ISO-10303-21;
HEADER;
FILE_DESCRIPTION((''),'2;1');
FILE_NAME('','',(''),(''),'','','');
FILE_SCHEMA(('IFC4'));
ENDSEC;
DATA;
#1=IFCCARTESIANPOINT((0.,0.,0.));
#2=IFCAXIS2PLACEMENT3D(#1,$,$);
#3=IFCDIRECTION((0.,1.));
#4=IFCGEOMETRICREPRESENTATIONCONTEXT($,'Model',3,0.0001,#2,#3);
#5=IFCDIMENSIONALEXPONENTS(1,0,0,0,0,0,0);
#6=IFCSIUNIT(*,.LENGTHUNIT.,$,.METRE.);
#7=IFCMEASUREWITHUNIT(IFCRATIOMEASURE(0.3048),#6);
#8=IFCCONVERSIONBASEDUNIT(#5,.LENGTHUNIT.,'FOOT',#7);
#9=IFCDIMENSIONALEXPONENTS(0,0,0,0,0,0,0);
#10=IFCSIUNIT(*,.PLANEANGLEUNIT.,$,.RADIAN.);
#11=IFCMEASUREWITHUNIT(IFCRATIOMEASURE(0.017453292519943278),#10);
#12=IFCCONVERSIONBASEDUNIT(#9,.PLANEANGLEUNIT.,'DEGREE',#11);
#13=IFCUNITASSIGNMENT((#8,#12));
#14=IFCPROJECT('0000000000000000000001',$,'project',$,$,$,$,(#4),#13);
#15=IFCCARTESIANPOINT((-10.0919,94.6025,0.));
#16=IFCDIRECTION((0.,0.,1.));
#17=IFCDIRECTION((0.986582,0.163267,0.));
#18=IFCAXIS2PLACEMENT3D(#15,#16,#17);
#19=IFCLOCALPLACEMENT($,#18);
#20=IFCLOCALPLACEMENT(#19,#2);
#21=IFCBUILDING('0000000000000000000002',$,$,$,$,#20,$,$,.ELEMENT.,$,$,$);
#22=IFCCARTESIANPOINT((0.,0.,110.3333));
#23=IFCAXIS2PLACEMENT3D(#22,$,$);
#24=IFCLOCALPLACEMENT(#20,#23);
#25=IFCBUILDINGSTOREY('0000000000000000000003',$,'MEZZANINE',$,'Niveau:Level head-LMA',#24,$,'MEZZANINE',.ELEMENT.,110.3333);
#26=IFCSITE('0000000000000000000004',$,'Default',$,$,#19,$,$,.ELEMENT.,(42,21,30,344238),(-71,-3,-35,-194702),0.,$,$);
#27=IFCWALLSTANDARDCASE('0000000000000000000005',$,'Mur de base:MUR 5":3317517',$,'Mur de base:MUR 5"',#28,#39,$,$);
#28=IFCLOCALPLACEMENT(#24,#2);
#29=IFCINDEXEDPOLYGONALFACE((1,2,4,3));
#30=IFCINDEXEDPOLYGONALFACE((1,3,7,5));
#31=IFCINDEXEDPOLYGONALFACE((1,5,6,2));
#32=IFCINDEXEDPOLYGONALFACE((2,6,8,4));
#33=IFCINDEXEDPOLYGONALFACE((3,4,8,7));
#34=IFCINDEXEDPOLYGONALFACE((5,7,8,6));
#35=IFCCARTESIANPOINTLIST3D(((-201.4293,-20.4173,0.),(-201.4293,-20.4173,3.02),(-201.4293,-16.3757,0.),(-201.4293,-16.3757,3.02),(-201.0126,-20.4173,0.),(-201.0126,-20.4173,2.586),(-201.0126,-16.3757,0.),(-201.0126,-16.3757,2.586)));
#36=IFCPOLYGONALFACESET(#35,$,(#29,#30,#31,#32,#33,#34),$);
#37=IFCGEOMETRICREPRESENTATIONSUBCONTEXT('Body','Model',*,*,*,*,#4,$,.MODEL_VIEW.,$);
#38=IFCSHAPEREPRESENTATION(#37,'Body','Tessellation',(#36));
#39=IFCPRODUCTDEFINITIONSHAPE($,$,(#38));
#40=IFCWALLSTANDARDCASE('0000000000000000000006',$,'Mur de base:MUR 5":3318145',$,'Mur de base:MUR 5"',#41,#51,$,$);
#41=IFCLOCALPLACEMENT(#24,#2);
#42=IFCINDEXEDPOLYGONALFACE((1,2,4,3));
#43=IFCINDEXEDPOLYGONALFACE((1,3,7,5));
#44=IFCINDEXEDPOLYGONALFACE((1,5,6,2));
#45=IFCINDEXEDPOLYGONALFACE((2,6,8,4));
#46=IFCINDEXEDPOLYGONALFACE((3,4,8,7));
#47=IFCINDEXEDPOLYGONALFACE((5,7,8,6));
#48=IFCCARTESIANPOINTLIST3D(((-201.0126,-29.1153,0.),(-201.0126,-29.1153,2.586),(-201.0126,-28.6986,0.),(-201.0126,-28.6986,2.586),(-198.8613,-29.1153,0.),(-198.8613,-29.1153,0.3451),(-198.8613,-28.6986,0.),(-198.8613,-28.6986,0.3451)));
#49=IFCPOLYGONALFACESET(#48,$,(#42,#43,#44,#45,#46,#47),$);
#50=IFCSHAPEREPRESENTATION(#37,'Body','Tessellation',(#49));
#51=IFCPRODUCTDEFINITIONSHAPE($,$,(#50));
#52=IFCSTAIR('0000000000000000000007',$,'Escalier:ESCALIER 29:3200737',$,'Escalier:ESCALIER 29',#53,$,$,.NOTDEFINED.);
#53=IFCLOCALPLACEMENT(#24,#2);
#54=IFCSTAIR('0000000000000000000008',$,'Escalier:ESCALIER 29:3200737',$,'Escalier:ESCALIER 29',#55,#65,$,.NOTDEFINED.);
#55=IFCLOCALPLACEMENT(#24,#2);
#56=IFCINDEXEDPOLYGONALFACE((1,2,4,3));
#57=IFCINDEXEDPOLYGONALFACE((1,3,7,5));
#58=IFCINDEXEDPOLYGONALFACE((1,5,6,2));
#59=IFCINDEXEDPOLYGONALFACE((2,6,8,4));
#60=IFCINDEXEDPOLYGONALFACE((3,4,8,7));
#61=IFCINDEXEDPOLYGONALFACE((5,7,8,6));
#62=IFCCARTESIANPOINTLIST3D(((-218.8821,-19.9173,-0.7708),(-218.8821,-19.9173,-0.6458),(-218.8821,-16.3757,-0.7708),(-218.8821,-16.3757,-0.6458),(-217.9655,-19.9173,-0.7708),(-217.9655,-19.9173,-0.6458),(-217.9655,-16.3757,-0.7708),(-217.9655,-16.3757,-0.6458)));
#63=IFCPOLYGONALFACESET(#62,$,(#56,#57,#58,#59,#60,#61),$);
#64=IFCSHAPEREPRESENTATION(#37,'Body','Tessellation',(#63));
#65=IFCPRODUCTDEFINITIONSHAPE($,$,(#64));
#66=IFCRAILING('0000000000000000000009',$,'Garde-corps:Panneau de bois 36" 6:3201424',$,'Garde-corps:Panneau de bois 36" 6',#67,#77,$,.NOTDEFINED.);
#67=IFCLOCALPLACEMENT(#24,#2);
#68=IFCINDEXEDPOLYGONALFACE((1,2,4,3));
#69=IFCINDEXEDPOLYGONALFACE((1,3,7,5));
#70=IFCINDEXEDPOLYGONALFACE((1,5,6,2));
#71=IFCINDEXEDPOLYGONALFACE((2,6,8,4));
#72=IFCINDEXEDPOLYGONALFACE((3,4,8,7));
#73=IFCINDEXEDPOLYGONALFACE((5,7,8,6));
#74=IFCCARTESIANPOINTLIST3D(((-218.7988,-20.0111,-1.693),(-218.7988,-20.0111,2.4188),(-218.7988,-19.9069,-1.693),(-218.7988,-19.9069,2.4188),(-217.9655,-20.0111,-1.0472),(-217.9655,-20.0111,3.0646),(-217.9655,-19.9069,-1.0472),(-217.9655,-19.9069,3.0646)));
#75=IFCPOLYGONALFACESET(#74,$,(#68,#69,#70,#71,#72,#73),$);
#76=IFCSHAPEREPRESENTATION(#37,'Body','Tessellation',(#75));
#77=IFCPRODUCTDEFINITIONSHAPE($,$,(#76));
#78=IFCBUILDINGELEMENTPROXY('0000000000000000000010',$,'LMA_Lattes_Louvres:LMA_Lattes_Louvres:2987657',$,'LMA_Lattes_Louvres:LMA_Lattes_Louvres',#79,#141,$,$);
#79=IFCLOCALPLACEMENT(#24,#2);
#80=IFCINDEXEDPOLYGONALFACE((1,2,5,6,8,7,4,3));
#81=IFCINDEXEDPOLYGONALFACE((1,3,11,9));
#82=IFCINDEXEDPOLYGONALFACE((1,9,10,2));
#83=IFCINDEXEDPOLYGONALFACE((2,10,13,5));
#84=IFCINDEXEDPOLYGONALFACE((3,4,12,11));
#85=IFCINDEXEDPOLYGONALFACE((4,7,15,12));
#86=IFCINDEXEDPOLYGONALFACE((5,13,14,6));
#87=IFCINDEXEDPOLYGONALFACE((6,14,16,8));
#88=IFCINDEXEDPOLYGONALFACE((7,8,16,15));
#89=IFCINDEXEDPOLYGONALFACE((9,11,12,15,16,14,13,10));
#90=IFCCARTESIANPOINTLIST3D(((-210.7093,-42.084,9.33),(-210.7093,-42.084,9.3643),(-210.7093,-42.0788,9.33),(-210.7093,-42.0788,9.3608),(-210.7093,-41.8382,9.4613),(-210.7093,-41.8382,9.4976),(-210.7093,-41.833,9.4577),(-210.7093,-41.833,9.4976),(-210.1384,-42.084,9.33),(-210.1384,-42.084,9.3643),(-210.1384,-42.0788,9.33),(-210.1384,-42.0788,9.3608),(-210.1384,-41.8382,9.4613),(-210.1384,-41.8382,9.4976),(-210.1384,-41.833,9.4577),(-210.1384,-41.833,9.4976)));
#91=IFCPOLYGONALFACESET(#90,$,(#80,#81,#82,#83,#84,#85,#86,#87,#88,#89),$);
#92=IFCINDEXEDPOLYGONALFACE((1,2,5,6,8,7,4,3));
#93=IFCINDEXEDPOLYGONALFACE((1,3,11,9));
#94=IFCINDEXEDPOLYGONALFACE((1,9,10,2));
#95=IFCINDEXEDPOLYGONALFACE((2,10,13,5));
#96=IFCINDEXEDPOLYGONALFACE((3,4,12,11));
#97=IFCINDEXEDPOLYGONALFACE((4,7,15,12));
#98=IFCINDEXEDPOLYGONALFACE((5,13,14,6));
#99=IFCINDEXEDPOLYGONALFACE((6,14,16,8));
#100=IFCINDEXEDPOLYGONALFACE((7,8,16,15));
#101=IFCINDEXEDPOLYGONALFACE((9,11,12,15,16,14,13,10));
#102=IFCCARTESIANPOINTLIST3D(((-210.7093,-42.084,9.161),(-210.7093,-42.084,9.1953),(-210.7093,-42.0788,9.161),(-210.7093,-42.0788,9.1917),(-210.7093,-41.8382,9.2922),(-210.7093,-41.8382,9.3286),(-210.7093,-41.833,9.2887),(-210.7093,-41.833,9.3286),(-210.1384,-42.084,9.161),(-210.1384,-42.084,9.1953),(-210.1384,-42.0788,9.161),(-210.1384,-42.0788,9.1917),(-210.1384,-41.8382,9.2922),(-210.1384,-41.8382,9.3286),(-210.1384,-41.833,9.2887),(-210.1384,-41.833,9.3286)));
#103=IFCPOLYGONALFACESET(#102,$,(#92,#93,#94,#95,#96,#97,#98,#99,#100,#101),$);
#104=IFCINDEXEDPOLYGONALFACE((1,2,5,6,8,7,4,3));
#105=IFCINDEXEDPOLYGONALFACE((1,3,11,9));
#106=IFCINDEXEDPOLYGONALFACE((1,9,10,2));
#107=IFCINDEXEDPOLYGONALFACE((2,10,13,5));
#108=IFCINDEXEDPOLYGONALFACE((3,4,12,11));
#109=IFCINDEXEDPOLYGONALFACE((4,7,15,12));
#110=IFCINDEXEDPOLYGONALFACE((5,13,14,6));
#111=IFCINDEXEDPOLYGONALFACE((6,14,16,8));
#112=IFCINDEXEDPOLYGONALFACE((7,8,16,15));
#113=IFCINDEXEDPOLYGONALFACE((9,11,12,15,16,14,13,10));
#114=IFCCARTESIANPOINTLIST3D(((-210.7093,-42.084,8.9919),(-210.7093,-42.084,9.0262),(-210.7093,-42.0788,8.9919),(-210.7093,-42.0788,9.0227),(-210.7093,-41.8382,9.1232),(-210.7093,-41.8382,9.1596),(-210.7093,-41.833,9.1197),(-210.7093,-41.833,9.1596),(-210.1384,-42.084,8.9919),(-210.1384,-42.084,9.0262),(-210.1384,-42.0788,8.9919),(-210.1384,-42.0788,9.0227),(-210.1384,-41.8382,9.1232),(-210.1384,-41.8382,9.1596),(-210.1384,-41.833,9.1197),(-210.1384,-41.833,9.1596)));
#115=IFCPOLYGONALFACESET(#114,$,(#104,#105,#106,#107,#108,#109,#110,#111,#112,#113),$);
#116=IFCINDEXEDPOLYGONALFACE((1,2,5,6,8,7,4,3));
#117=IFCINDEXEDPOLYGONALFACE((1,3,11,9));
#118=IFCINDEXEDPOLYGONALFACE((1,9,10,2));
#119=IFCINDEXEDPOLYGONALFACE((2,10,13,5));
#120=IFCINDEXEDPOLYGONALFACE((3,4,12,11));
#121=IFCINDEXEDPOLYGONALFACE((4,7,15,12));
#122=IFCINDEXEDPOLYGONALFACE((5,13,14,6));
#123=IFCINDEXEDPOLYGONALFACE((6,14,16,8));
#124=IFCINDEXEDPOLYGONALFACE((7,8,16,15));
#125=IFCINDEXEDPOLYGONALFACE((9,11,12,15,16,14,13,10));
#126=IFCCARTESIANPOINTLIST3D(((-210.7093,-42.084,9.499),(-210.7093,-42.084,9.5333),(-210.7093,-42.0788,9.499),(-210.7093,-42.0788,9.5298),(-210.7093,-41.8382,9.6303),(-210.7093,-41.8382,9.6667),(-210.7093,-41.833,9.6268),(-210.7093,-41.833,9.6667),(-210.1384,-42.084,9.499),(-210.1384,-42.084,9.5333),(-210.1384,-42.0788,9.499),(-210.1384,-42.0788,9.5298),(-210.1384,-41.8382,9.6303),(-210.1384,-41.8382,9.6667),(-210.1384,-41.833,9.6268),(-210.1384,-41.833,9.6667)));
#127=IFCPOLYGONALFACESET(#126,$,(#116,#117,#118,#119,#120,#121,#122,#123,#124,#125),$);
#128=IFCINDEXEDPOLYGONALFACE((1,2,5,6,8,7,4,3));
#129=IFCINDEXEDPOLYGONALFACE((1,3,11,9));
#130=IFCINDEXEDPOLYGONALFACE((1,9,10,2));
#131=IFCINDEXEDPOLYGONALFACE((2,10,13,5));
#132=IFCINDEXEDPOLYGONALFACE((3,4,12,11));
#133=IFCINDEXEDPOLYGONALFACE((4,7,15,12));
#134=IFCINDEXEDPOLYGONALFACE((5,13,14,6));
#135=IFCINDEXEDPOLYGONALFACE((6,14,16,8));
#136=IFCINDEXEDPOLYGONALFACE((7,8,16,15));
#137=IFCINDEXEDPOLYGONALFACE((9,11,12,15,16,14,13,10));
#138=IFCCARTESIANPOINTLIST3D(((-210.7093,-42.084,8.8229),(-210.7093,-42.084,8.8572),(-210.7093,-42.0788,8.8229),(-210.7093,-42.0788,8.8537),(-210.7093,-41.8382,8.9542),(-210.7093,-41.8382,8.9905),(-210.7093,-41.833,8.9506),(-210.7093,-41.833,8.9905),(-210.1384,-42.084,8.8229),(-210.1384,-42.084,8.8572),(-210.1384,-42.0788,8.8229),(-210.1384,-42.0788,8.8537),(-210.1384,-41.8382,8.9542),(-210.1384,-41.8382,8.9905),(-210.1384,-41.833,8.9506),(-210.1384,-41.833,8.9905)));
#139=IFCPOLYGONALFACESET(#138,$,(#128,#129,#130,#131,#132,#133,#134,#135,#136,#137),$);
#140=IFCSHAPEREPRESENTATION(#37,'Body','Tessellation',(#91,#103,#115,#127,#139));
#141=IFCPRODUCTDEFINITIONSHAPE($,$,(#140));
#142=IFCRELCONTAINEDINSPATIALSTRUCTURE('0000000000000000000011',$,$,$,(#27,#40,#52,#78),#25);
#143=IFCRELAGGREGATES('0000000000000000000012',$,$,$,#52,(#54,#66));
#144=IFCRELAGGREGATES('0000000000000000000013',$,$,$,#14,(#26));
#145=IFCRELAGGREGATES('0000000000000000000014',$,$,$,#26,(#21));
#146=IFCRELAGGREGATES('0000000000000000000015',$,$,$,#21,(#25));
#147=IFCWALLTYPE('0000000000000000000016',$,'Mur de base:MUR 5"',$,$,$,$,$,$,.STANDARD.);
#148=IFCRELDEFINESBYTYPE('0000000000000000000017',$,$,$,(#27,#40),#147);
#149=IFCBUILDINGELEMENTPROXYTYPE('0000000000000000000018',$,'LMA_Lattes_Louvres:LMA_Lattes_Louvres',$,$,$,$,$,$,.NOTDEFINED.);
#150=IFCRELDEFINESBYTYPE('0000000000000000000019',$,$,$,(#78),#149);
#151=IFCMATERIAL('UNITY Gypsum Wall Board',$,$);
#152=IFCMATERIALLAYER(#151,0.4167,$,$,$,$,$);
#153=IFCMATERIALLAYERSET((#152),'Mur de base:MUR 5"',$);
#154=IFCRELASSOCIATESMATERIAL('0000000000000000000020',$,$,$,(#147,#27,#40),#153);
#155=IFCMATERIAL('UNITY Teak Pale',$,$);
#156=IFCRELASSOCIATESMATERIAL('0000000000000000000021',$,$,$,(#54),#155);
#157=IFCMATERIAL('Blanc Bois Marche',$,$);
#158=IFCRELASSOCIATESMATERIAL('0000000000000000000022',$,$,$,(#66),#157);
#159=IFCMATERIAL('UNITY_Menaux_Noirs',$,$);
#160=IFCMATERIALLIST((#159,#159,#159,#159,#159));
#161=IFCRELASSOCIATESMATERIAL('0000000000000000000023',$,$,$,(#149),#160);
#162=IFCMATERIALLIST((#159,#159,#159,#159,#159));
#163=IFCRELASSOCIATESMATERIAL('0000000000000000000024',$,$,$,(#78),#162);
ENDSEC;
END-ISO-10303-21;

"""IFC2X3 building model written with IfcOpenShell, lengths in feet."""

from ifc_helpers import new_model, entity, si_unit, converted_unit, direction, frame, frame_2d, origin, place, context, subcontext, project, spatial, polyline, rectangle, outline, extrude, clip, bounded_halfspace, source, transform, mapped, material, material_list, layer, layer_set, layer_usage, type_object, type_shapes, element, aggregate, save


model = new_model("IFC2X3")

# Units and contexts
model_context = context("Model", 3, precision=0.0001, world=origin(), true_north=direction((0.0, 1.0)))
body_context = subcontext(model_context, "Body", "Model", "MODEL_VIEW")
ifc_project = project(units=[converted_unit("LENGTHUNIT", "FOOT", entity("IfcRatioMeasure", 0.3048), si_unit("LENGTHUNIT", "METRE"), dimensions=[1, 0, 0, 0, 0, 0, 0]), converted_unit("PLANEANGLEUNIT", "DEGREE", entity("IfcRatioMeasure", 0.017453292519943278), si_unit("PLANEANGLEUNIT", "RADIAN"), dimensions=[0, 0, 0, 0, 0, 0, 0])], contexts=[model_context])

# Site, building, storey
site_placement = place(None, frame((-10.0919, 94.6025, 0.0), z_axis=(0.0, 0.0, 1.0), x_axis=(0.986582, 0.163267, 0.0)))
site = spatial("IfcSite", under=ifc_project, at=site_placement, Name="Default", CompositionType="ELEMENT", RefLatitude=(42, 21, 30, 344238), RefLongitude=(-71, -3, -35, -194702), RefElevation=0.0)
building_placement = place(site_placement, origin())
building = spatial("IfcBuilding", under=site, at=building_placement, CompositionType="ELEMENT")
storey_placement = place(building_placement, frame((0.0, 0.0, 110.3333)))
storey = spatial("IfcBuildingStorey", under=building, at=storey_placement, Name="MEZZANINE", ObjectType="Niveau:Level head-LMA", LongName="MEZZANINE", CompositionType="ELEMENT", Elevation=110.3333)

# Shared definitions
ifc_material_1 = material(Name="UNITY Gypsum Wall Board")
ifc_layer_1 = layer(ifc_material_1, 0.4167)
ifc_layer_set_1 = layer_set([ifc_layer_1], Name="Mur de base:MUR 5\"")
wall_type_1 = type_object("IfcWallType", Name="Mur de base:MUR 5\"", PredefinedType="STANDARD", material=ifc_layer_set_1)

# Wall
ifc_layer_usage_1 = layer_usage(ifc_layer_set_1, "AXIS2", "NEGATIVE", 0.2083)
wall_1_placement = place(storey_placement, frame((-201.2209, -20.4173, 0.0), z_axis=(0.0, 0.0, 1.0), x_axis=(0.0, 1.0, 0.0)))
element("IfcWallStandardCase", 1, at=wall_1_placement, inside=storey, type_object=wall_type_1, material=ifc_layer_usage_1, Name="Mur de base:MUR 5\":3317517", ObjectType="Mur de base:MUR 5\"", context=body_context, shape_type="Clipping", body=[
    clip(extrude(rectangle(XDim=4.0417, YDim=0.4167, at=frame_2d((2.0208, 0.0), x_axis=(-1.0, 0.0))), origin(), (0.0, 0.0, 1.0), 3.02), bounded_halfspace(frame((0.0, -0.2083, 2.586), z_axis=(0.0, -0.721387, 0.692532), x_axis=(1.0, 0.0, 0.0)), False, frame((0.0, -0.2083, 2.586)), polyline([(0.0, 0.0), (4.0417, 0.0), (4.0417, 0.4167), (0.0, 0.4167), (0.0, 0.0)]))),
])

# Wall
ifc_layer_usage_2 = layer_usage(ifc_layer_set_1, "AXIS2", "NEGATIVE", 0.2083)
wall_2_placement = place(storey_placement, frame((-198.8613, -28.9069, 0.0), z_axis=(0.0, 0.0, 1.0), x_axis=(-1.0, 0.0, 0.0)))
element("IfcWallStandardCase", 2, at=wall_2_placement, inside=storey, type_object=wall_type_1, material=ifc_layer_usage_2, Name="Mur de base:MUR 5\":3318145", ObjectType="Mur de base:MUR 5\"", context=body_context, shape_type="Clipping", body=[
    clip(extrude(rectangle(XDim=2.1513, YDim=0.4167, at=frame_2d((1.0756, 0.0), x_axis=(-1.0, 0.0))), origin(), (0.0, 0.0, 1.0), 2.586), bounded_halfspace(frame((0.0, -0.2083, 0.3451), z_axis=(-0.721387, 0.0, 0.692532), x_axis=(0.0, -1.0, 0.0)), False, frame((0.0, -0.2083, 0.3451)), polyline([(0.0, 0.0), (2.1513, 0.0), (2.1513, 0.4167), (0.0, 0.4167), (0.0, 0.0)]))),
])

# Stairs
stair_1_placement = place(storey_placement, origin())
stair_1 = element("IfcStair", 3, at=stair_1_placement, inside=storey, Name="Escalier:ESCALIER 29:3200737", ObjectType="Escalier:ESCALIER 29", ShapeType="NOTDEFINED")
ifc_material_2 = material(Name="UNITY Teak Pale")
stair_2_placement = place(stair_1_placement, origin())
stair_2 = element("IfcStair", 4, at=stair_2_placement, material=ifc_material_2, Name="Escalier:ESCALIER 29:3200737", ObjectType="Escalier:ESCALIER 29", ShapeType="NOTDEFINED", context=body_context, shape_type="SweptSolid", body=[
    extrude(rectangle(XDim=0.9167, YDim=3.5417, at=frame_2d((0.0, 0.0), x_axis=(1.0, 0.0))), frame((-218.4238, -18.1465, -0.7708), z_axis=(0.0, 0.0, 1.0), x_axis=(-1.0, 0.0, 0.0)), (0.0, 0.0, 1.0), 0.125),
])

# Railing
ifc_material_3 = material(Name="Blanc Bois Marche")
railing_1_placement = place(stair_1_placement, frame((0.0, 0.0, -1.0)))
railing_1 = element("IfcRailing", 5, at=railing_1_placement, material=ifc_material_3, Name="Garde-corps:Panneau de bois 36\" 6:3201424", ObjectType="Garde-corps:Panneau de bois 36\" 6", PredefinedType="NOTDEFINED", context=body_context, shape_type="SweptSolid", body=[
    extrude(outline(polyline([(0.7322, -1.625), (1.7865, -1.625), (-0.7322, 1.625), (-1.7865, 1.625), (0.7322, -1.625)])), frame((-218.3821, -20.0111, 1.6858), z_axis=(0.0, 1.0, 0.0), x_axis=(0.790415, 0.0, 0.612572)), (0.0, 0.0, 1.0), 0.1042),
])
aggregate(stair_1, [stair_2, railing_1])

# Building element proxy
ifc_material_4 = material(Name="UNITY_Menaux_Noirs")
ifc_material_list_1 = material_list([ifc_material_4, ifc_material_4, ifc_material_4, ifc_material_4, ifc_material_4])
ifc_material_list_2 = material_list([ifc_material_4, ifc_material_4, ifc_material_4, ifc_material_4, ifc_material_4])
building_element_proxy_type_1 = type_object("IfcBuildingElementProxyType", Name="LMA_Lattes_Louvres:LMA_Lattes_Louvres", PredefinedType="NOTDEFINED", material=ifc_material_list_2)
shared_shape_1 = source(origin(), body_context, "Body", "SweptSolid", [
    extrude(outline(polyline([(0.0489, 0.1203), (0.0852, 0.1203), (0.0852, 0.1255), (0.0453, 0.1255), (-0.0517, -0.1203), (-0.0824, -0.1203), (-0.0824, -0.1255), (-0.0481, -0.1255), (0.0489, 0.1203)])), frame((-0.2854, 0.1255, 0.5895), z_axis=(1.0, 0.0, 0.0), x_axis=(0.0, 0.0, 1.0)), (0.0, 0.0, 1.0), 0.5709),
    extrude(outline(polyline([(0.0489, 0.1203), (0.0852, 0.1203), (0.0852, 0.1255), (0.0453, 0.1255), (-0.0517, -0.1203), (-0.0824, -0.1203), (-0.0824, -0.1255), (-0.0481, -0.1255), (0.0489, 0.1203)])), frame((-0.2854, 0.1255, 0.4205), z_axis=(1.0, 0.0, 0.0), x_axis=(0.0, 0.0, 1.0)), (0.0, 0.0, 1.0), 0.5709),
    extrude(outline(polyline([(0.0489, 0.1203), (0.0852, 0.1203), (0.0852, 0.1255), (0.0453, 0.1255), (-0.0517, -0.1203), (-0.0824, -0.1203), (-0.0824, -0.1255), (-0.0481, -0.1255), (0.0489, 0.1203)])), frame((-0.2854, 0.1255, 0.2514), z_axis=(1.0, 0.0, 0.0), x_axis=(0.0, 0.0, 1.0)), (0.0, 0.0, 1.0), 0.5709),
    extrude(outline(polyline([(0.0489, 0.1203), (0.0852, 0.1203), (0.0852, 0.1255), (0.0453, 0.1255), (-0.0517, -0.1203), (-0.0824, -0.1203), (-0.0824, -0.1255), (-0.0481, -0.1255), (0.0489, 0.1203)])), frame((-0.2854, 0.1255, 0.7585), z_axis=(1.0, 0.0, 0.0), x_axis=(0.0, 0.0, 1.0)), (0.0, 0.0, 1.0), 0.5709),
    extrude(outline(polyline([(0.0489, 0.1203), (0.0852, 0.1203), (0.0852, 0.1255), (0.0453, 0.1255), (-0.0517, -0.1203), (-0.0824, -0.1203), (-0.0824, -0.1255), (-0.0481, -0.1255), (0.0489, 0.1203)])), frame((-0.2854, 0.1255, 0.0824), z_axis=(1.0, 0.0, 0.0), x_axis=(0.0, 0.0, 1.0)), (0.0, 0.0, 1.0), 0.5709),
])
type_shapes(building_element_proxy_type_1, [shared_shape_1])
proxy_1_placement = place(storey_placement, frame((-210.4238, -41.833, 8.8229), z_axis=(0.0, 0.0, 1.0), x_axis=(-1.0, 0.0, 0.0)))
element("IfcBuildingElementProxy", 6, at=proxy_1_placement, inside=storey, type_object=building_element_proxy_type_1, material=ifc_material_list_1, Name="LMA_Lattes_Louvres:LMA_Lattes_Louvres:2987657", ObjectType="LMA_Lattes_Louvres:LMA_Lattes_Louvres", context=body_context, shape_type="MappedRepresentation", body=[
    mapped(shared_shape_1, transform((0.0, 0.0, 0.0), scale=1.0)),
])

save(model, "model.ifc")
